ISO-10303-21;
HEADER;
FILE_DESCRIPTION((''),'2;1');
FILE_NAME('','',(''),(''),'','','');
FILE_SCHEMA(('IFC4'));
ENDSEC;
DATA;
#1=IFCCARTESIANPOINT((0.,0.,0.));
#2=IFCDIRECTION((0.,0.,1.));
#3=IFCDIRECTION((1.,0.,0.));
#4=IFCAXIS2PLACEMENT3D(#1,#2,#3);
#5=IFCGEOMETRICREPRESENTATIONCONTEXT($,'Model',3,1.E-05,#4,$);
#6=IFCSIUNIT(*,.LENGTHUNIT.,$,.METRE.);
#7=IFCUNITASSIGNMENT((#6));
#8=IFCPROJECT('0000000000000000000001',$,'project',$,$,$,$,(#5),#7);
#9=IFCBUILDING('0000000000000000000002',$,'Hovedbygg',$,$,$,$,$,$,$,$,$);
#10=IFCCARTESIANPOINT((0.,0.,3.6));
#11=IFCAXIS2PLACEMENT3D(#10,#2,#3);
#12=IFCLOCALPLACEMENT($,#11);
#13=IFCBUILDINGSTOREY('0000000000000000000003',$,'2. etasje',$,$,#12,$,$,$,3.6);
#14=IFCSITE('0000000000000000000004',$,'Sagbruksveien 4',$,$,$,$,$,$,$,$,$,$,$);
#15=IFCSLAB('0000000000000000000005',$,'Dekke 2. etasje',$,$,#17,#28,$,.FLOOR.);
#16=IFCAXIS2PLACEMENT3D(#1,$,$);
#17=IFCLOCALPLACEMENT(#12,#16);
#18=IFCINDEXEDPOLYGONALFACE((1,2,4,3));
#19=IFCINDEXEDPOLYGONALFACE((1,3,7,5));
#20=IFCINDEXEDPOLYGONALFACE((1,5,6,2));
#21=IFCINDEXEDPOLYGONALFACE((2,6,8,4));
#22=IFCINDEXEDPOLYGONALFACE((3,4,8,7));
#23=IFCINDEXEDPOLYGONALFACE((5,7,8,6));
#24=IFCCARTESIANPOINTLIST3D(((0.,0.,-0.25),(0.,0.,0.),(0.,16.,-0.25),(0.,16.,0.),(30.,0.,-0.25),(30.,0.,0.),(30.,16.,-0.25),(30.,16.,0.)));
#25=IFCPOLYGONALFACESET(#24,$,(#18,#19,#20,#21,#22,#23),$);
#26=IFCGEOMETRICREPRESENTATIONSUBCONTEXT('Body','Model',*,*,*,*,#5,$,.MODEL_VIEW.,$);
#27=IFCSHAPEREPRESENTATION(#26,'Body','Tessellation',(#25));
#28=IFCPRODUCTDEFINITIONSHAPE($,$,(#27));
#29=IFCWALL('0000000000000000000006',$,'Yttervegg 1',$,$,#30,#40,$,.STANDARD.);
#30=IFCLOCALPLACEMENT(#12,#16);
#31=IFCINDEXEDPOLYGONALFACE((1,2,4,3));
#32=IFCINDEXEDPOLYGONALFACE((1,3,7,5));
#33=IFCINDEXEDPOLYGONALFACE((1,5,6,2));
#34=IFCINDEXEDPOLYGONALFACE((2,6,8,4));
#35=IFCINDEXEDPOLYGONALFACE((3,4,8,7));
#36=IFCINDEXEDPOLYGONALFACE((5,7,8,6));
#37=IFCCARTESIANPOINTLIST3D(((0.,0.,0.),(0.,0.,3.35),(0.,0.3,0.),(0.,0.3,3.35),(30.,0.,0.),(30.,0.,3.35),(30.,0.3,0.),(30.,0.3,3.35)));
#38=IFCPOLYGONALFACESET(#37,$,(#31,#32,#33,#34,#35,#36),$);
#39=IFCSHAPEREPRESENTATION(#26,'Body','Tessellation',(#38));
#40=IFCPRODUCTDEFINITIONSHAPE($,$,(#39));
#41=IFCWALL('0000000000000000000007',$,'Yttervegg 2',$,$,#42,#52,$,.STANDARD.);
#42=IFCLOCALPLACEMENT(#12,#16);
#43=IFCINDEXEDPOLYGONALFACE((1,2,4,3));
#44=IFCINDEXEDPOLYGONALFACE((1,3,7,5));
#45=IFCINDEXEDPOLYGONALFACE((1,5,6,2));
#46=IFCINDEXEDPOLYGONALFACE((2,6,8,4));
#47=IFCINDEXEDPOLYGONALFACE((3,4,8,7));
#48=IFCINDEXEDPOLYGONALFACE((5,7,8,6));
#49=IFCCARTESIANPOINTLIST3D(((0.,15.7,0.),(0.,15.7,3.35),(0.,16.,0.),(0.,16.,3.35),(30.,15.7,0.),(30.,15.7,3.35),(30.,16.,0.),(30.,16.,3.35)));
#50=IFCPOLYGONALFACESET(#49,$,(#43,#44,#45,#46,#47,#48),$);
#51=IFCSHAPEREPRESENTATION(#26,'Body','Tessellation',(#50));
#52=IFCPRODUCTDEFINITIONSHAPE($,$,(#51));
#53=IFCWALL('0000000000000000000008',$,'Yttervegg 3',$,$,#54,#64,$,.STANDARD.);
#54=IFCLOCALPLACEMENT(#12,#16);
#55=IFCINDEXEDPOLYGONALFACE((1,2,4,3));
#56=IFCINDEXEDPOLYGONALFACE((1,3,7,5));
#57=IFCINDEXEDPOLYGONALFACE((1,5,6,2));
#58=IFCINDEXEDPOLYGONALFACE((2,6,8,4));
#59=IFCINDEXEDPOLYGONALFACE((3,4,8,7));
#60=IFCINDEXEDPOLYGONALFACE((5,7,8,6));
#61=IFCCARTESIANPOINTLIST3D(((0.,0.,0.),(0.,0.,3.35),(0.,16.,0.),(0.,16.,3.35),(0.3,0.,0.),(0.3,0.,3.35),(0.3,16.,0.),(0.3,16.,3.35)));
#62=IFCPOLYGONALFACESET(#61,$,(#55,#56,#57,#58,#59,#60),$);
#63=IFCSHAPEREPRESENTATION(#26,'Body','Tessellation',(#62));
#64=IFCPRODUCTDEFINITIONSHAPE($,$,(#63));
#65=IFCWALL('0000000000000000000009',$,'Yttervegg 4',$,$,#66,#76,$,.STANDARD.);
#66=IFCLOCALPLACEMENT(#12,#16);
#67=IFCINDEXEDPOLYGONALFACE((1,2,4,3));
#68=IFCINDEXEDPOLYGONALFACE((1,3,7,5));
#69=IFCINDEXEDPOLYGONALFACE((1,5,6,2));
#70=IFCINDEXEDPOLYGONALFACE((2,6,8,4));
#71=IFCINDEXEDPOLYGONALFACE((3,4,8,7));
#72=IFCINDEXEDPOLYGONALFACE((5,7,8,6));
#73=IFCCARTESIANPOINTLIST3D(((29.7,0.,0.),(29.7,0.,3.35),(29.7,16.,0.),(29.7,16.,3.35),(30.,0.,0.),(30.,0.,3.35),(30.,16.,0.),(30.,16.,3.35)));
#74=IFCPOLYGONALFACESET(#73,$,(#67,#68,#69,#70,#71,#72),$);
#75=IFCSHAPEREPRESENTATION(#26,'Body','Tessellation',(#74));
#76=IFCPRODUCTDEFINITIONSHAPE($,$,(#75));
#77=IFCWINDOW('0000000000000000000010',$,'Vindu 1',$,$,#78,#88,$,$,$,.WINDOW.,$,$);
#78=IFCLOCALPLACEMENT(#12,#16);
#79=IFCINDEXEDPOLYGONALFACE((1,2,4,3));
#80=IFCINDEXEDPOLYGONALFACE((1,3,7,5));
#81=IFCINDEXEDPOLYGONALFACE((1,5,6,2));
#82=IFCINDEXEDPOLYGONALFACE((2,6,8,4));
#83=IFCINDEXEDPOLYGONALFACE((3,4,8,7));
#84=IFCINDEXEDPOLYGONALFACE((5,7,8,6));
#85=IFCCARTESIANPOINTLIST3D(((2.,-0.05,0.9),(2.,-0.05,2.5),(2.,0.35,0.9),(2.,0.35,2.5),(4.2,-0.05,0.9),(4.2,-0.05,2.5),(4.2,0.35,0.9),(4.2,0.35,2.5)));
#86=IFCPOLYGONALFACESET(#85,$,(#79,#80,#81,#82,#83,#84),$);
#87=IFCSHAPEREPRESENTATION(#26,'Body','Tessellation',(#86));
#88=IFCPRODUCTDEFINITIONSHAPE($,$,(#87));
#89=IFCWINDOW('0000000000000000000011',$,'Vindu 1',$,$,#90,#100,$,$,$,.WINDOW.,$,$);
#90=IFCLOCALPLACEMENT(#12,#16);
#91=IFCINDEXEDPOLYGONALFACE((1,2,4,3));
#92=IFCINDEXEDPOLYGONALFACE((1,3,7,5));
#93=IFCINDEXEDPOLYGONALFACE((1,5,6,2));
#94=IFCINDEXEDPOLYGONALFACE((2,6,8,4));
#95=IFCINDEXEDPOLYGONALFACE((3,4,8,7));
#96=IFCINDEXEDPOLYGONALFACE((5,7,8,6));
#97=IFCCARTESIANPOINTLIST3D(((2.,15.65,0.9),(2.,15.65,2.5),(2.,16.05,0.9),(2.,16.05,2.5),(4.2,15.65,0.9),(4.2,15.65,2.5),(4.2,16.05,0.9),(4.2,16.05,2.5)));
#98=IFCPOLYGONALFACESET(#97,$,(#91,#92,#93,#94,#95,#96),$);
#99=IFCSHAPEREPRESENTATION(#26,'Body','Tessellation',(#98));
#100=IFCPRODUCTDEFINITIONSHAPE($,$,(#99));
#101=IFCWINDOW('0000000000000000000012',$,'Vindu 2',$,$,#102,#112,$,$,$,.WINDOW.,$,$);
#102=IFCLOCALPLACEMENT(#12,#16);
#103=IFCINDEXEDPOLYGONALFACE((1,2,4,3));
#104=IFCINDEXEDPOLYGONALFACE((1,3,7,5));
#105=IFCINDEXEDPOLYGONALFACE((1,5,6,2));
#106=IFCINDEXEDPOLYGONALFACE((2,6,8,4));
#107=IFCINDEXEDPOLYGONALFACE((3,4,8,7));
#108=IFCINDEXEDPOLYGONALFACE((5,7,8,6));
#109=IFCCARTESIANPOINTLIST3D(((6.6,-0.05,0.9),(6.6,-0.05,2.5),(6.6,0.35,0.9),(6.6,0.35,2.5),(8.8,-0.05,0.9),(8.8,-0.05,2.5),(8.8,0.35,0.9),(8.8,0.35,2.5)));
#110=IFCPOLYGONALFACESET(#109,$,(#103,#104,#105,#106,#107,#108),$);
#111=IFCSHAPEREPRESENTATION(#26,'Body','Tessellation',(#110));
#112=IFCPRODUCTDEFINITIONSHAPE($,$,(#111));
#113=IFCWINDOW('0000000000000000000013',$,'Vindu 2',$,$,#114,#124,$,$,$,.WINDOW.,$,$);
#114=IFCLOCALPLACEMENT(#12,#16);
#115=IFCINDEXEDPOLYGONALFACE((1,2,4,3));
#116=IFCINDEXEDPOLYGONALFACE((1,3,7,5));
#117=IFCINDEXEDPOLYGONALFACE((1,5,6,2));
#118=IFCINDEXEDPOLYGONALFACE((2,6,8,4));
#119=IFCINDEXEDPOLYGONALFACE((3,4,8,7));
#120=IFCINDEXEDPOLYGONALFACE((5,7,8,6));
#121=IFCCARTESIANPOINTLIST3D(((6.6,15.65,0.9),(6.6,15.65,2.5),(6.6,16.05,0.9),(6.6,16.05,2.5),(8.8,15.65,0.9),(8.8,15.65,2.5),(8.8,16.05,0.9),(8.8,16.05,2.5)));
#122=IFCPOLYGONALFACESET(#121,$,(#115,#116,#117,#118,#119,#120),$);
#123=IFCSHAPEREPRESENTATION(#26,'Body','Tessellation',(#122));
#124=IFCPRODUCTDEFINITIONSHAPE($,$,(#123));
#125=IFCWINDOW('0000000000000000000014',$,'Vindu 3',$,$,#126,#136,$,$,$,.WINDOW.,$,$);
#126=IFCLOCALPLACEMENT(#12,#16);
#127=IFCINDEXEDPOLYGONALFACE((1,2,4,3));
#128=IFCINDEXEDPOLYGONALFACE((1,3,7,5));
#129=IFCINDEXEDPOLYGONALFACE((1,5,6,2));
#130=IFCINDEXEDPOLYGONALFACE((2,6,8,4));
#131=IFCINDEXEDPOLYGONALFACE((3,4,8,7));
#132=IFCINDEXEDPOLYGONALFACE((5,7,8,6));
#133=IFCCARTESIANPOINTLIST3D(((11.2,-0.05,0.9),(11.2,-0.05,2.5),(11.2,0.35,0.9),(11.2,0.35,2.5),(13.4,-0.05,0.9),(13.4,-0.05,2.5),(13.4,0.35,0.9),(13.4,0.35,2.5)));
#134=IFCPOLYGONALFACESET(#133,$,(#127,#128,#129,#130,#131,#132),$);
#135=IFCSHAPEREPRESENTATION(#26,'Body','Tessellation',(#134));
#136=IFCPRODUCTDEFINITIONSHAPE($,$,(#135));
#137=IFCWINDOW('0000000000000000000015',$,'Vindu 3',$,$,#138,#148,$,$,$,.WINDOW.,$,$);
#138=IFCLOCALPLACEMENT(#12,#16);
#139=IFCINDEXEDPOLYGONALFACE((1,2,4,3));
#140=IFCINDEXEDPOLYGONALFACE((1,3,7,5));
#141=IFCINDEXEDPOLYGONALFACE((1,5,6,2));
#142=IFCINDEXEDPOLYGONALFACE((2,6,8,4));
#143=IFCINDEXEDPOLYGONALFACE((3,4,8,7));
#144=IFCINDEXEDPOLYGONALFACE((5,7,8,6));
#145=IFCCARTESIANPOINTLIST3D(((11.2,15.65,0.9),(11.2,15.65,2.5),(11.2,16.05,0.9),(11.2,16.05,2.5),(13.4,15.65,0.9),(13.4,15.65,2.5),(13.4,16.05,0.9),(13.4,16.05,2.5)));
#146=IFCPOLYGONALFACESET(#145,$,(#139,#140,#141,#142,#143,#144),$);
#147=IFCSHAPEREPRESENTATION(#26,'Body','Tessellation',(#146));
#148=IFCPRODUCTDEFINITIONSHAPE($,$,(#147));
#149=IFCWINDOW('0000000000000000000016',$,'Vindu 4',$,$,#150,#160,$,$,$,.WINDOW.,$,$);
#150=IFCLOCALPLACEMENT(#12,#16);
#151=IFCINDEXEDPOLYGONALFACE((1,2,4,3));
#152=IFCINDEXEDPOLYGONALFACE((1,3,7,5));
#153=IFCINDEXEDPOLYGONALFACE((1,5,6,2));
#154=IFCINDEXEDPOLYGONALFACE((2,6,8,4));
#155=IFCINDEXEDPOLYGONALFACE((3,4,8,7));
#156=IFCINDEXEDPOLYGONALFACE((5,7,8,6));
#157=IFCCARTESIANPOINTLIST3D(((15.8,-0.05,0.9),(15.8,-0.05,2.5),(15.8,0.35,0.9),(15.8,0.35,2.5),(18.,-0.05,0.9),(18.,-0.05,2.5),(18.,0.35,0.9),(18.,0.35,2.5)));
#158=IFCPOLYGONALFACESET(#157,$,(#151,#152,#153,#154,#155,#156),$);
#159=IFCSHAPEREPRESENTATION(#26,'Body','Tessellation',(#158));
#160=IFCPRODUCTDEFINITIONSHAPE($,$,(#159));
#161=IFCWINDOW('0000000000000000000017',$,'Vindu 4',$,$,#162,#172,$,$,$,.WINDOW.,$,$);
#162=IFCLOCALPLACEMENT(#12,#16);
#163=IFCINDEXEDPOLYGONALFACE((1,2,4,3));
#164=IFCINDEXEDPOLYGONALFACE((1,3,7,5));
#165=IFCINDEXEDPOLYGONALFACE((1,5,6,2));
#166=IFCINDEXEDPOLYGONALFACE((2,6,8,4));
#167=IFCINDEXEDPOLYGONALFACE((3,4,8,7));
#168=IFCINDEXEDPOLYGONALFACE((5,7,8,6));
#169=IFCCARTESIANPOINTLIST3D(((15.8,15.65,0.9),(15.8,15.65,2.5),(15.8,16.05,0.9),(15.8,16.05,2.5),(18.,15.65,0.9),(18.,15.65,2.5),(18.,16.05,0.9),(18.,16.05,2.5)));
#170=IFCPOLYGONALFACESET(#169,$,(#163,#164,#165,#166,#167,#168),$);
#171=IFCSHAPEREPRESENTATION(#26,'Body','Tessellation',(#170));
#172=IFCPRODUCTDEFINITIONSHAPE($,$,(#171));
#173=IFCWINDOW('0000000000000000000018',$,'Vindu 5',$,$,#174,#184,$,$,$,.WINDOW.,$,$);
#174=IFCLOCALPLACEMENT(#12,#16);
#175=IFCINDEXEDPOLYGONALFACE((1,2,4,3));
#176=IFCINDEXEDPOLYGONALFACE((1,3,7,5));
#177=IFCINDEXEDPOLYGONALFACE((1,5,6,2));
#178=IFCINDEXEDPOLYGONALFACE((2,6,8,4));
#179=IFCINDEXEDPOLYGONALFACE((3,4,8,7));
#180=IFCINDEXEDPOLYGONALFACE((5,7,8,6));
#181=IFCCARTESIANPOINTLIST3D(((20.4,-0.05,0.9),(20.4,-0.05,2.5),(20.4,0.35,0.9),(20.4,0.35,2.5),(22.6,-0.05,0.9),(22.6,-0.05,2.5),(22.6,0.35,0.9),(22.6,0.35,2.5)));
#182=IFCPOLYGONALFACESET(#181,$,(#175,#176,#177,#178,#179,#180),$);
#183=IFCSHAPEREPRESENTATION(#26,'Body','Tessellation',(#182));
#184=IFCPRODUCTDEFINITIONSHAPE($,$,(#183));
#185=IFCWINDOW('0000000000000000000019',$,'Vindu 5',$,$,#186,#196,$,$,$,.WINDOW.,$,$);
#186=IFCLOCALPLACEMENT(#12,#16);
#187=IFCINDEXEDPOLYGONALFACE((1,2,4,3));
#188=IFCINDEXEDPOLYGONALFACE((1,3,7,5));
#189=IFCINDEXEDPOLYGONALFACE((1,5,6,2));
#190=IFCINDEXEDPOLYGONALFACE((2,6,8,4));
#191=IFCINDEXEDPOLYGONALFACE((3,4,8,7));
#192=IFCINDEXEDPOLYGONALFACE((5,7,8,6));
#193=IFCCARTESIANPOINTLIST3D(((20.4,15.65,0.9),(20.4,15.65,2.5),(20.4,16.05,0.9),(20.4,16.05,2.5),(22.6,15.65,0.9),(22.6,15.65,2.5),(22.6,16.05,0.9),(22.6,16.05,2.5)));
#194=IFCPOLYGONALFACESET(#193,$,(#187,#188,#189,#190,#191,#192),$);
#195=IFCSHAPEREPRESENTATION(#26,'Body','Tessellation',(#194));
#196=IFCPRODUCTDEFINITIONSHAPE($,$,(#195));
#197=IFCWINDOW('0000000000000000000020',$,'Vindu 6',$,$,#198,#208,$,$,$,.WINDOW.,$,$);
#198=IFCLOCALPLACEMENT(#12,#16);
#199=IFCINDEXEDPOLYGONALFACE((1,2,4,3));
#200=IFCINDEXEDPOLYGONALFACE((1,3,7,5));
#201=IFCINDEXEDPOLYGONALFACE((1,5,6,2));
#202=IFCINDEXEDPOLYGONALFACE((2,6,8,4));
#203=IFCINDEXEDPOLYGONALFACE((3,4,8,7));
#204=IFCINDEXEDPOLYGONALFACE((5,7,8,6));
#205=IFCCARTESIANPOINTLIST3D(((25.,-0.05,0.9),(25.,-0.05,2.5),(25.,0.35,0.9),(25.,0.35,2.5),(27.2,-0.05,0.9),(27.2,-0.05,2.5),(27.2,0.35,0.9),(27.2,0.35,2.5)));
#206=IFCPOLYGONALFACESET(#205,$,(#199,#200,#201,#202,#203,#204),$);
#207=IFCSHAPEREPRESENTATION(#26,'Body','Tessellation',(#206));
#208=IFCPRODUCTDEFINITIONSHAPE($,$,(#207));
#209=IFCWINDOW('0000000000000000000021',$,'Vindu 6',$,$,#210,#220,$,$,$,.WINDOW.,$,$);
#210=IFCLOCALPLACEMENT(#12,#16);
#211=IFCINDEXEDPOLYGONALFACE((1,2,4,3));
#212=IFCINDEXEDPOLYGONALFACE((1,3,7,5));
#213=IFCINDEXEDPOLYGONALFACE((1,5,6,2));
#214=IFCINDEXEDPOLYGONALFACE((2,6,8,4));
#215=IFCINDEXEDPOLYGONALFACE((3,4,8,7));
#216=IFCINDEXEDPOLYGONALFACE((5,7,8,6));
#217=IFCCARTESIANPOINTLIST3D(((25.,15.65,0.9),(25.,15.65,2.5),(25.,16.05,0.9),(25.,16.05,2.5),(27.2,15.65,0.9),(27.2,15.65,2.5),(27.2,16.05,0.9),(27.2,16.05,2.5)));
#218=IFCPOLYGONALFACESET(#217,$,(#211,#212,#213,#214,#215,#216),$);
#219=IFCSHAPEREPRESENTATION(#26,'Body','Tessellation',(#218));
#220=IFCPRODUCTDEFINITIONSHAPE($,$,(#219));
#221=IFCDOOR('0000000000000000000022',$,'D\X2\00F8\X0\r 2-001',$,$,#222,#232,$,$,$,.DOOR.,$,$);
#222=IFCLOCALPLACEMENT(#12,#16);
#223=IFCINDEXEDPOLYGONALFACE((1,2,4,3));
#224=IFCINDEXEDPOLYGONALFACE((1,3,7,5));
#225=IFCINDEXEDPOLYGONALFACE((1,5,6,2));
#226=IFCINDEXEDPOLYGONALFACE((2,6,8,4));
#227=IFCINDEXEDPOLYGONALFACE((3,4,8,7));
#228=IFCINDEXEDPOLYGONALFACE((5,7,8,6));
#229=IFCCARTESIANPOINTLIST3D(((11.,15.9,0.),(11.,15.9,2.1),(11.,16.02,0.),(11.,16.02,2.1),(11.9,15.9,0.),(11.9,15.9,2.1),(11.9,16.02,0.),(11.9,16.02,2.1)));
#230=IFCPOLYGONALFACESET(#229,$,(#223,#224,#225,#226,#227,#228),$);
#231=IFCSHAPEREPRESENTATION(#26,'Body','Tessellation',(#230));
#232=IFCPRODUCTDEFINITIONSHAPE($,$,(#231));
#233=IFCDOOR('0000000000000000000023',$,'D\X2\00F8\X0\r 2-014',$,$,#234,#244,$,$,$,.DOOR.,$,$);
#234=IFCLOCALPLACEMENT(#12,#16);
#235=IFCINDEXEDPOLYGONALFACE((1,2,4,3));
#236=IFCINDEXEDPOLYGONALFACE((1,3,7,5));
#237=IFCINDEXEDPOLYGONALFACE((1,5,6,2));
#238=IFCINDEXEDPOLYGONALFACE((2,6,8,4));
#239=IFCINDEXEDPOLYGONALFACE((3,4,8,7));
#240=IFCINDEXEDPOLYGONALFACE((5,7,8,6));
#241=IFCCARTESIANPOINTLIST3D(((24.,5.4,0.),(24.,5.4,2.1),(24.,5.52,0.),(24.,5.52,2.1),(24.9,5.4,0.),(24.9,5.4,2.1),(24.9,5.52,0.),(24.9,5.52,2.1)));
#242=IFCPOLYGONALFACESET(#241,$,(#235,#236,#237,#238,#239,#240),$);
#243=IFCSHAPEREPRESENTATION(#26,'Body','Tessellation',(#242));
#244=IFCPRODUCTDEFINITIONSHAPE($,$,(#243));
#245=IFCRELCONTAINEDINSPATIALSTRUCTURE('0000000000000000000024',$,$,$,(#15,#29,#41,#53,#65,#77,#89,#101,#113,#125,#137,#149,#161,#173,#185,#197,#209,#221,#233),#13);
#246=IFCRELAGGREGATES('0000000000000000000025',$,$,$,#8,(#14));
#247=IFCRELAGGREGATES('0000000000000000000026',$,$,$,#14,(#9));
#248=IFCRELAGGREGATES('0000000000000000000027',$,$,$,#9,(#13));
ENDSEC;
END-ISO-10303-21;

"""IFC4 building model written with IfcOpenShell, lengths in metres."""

from ifc_helpers import new_model, si_unit, frame, origin_with_axes, place, context, subcontext, project, spatial, line, indexed_curve, outline, extrude, element, save


model = new_model("IFC4")

# Units and contexts
model_context = context("Model", 3, precision=1e-05, world=origin_with_axes())
body_context = subcontext(model_context, "Body", "Model", "MODEL_VIEW")
ifc_project = project(units=[si_unit("LENGTHUNIT", "METRE")], contexts=[model_context])

# Site, building, storey
site = spatial("IfcSite", under=ifc_project, Name="Sagbruksveien 4")
building = spatial("IfcBuilding", under=site, Name="Hovedbygg")
storey_placement = place(None, frame((0.0, 0.0, 3.6), z_axis=(0.0, 0.0, 1.0), x_axis=(1.0, 0.0, 0.0)))
storey = spatial("IfcBuildingStorey", under=building, at=storey_placement, Name="2. etasje", Elevation=3.6)

# Slab
slab_placement = place(storey_placement, frame((0.0, 0.0, -0.25), z_axis=(0.0, 0.0, 1.0), x_axis=(1.0, 0.0, 0.0)))
element("IfcSlab", 1, at=slab_placement, inside=storey, Name="Dekke 2. etasje", PredefinedType="FLOOR", context=body_context, shape_type="SweptSolid", body=[
    extrude(outline(indexed_curve([(0.0, 0.0), (30.0, 0.0), (30.0, 16.0), (0.0, 16.0)], segments=[line(1, 2, 3, 4, 1)])), origin_with_axes(), (0.0, 0.0, 1.0), 0.25),
])

# Walls
for number, where, z_axis, x_axis, name in (
    (2, (0.0, 0.0, 0.0), (0.0, 0.0, 1.0), (1.0, 0.0, 0.0), "Yttervegg 1"),
    (3, (0.0, 15.7, 0.0), (0.0, 0.0, 1.0), (1.0, 0.0, 0.0), "Yttervegg 2"),
):
    element("IfcWall", number, at=place(storey_placement, frame(where, z_axis=z_axis, x_axis=x_axis)), inside=storey, Name=name, PredefinedType="STANDARD", context=body_context, shape_type="SweptSolid", body=[
        extrude(outline(indexed_curve([(0.0, 0.0), (30.0, 0.0), (30.0, 0.3), (0.0, 0.3)], segments=[line(1, 2, 3, 4, 1)])), origin_with_axes(), (0.0, 0.0, 1.0), 3.35),
    ])
for number, where, z_axis, x_axis, name in (
    (4, (0.0, 0.0, 0.0), (0.0, 0.0, 1.0), (1.0, 0.0, 0.0), "Yttervegg 3"),
    (5, (29.7, 0.0, 0.0), (0.0, 0.0, 1.0), (1.0, 0.0, 0.0), "Yttervegg 4"),
):
    element("IfcWall", number, at=place(storey_placement, frame(where, z_axis=z_axis, x_axis=x_axis)), inside=storey, Name=name, PredefinedType="STANDARD", context=body_context, shape_type="SweptSolid", body=[
        extrude(outline(indexed_curve([(0.0, 0.0), (0.3, 0.0), (0.3, 16.0), (0.0, 16.0)], segments=[line(1, 2, 3, 4, 1)])), origin_with_axes(), (0.0, 0.0, 1.0), 3.35),
    ])

# Windows
for number, where, z_axis, x_axis, name in (
    (6, (2.0, -0.05, 0.9), (0.0, 0.0, 1.0), (1.0, 0.0, 0.0), "Vindu 1"),
    (7, (2.0, 15.65, 0.9), (0.0, 0.0, 1.0), (1.0, 0.0, 0.0), "Vindu 1"),
    (8, (6.6, -0.05, 0.9), (0.0, 0.0, 1.0), (1.0, 0.0, 0.0), "Vindu 2"),
    (9, (6.6, 15.65, 0.9), (0.0, 0.0, 1.0), (1.0, 0.0, 0.0), "Vindu 2"),
    (10, (11.2, -0.05, 0.9), (0.0, 0.0, 1.0), (1.0, 0.0, 0.0), "Vindu 3"),
    (11, (11.2, 15.65, 0.9), (0.0, 0.0, 1.0), (1.0, 0.0, 0.0), "Vindu 3"),
    (12, (15.8, -0.05, 0.9), (0.0, 0.0, 1.0), (1.0, 0.0, 0.0), "Vindu 4"),
    (13, (15.8, 15.65, 0.9), (0.0, 0.0, 1.0), (1.0, 0.0, 0.0), "Vindu 4"),
    (14, (20.4, -0.05, 0.9), (0.0, 0.0, 1.0), (1.0, 0.0, 0.0), "Vindu 5"),
    (15, (20.4, 15.65, 0.9), (0.0, 0.0, 1.0), (1.0, 0.0, 0.0), "Vindu 5"),
    (16, (25.0, -0.05, 0.9), (0.0, 0.0, 1.0), (1.0, 0.0, 0.0), "Vindu 6"),
    (17, (25.0, 15.65, 0.9), (0.0, 0.0, 1.0), (1.0, 0.0, 0.0), "Vindu 6"),
):
    element("IfcWindow", number, at=place(storey_placement, frame(where, z_axis=z_axis, x_axis=x_axis)), inside=storey, Name=name, PredefinedType="WINDOW", context=body_context, shape_type="SweptSolid", body=[
        extrude(outline(indexed_curve([(0.0, 0.0), (2.2, 0.0), (2.2, 0.4), (0.0, 0.4)], segments=[line(1, 2, 3, 4, 1)])), origin_with_axes(), (0.0, 0.0, 1.0), 1.6),
    ])

# Doors
for number, where, z_axis, x_axis, name in (
    (18, (11.0, 15.9, 0.0), (0.0, 0.0, 1.0), (1.0, 0.0, 0.0), "Dør 2-001"),
    (19, (24.0, 5.4, 0.0), (0.0, 0.0, 1.0), (1.0, 0.0, 0.0), "Dør 2-014"),
):
    element("IfcDoor", number, at=place(storey_placement, frame(where, z_axis=z_axis, x_axis=x_axis)), inside=storey, Name=name, PredefinedType="DOOR", context=body_context, shape_type="SweptSolid", body=[
        extrude(outline(indexed_curve([(0.0, 0.0), (0.9, 0.0), (0.9, 0.12), (0.0, 0.12)], segments=[line(1, 2, 3, 4, 1)])), origin_with_axes(), (0.0, 0.0, 1.0), 2.1),
    ])

save(model, "model.ifc")
